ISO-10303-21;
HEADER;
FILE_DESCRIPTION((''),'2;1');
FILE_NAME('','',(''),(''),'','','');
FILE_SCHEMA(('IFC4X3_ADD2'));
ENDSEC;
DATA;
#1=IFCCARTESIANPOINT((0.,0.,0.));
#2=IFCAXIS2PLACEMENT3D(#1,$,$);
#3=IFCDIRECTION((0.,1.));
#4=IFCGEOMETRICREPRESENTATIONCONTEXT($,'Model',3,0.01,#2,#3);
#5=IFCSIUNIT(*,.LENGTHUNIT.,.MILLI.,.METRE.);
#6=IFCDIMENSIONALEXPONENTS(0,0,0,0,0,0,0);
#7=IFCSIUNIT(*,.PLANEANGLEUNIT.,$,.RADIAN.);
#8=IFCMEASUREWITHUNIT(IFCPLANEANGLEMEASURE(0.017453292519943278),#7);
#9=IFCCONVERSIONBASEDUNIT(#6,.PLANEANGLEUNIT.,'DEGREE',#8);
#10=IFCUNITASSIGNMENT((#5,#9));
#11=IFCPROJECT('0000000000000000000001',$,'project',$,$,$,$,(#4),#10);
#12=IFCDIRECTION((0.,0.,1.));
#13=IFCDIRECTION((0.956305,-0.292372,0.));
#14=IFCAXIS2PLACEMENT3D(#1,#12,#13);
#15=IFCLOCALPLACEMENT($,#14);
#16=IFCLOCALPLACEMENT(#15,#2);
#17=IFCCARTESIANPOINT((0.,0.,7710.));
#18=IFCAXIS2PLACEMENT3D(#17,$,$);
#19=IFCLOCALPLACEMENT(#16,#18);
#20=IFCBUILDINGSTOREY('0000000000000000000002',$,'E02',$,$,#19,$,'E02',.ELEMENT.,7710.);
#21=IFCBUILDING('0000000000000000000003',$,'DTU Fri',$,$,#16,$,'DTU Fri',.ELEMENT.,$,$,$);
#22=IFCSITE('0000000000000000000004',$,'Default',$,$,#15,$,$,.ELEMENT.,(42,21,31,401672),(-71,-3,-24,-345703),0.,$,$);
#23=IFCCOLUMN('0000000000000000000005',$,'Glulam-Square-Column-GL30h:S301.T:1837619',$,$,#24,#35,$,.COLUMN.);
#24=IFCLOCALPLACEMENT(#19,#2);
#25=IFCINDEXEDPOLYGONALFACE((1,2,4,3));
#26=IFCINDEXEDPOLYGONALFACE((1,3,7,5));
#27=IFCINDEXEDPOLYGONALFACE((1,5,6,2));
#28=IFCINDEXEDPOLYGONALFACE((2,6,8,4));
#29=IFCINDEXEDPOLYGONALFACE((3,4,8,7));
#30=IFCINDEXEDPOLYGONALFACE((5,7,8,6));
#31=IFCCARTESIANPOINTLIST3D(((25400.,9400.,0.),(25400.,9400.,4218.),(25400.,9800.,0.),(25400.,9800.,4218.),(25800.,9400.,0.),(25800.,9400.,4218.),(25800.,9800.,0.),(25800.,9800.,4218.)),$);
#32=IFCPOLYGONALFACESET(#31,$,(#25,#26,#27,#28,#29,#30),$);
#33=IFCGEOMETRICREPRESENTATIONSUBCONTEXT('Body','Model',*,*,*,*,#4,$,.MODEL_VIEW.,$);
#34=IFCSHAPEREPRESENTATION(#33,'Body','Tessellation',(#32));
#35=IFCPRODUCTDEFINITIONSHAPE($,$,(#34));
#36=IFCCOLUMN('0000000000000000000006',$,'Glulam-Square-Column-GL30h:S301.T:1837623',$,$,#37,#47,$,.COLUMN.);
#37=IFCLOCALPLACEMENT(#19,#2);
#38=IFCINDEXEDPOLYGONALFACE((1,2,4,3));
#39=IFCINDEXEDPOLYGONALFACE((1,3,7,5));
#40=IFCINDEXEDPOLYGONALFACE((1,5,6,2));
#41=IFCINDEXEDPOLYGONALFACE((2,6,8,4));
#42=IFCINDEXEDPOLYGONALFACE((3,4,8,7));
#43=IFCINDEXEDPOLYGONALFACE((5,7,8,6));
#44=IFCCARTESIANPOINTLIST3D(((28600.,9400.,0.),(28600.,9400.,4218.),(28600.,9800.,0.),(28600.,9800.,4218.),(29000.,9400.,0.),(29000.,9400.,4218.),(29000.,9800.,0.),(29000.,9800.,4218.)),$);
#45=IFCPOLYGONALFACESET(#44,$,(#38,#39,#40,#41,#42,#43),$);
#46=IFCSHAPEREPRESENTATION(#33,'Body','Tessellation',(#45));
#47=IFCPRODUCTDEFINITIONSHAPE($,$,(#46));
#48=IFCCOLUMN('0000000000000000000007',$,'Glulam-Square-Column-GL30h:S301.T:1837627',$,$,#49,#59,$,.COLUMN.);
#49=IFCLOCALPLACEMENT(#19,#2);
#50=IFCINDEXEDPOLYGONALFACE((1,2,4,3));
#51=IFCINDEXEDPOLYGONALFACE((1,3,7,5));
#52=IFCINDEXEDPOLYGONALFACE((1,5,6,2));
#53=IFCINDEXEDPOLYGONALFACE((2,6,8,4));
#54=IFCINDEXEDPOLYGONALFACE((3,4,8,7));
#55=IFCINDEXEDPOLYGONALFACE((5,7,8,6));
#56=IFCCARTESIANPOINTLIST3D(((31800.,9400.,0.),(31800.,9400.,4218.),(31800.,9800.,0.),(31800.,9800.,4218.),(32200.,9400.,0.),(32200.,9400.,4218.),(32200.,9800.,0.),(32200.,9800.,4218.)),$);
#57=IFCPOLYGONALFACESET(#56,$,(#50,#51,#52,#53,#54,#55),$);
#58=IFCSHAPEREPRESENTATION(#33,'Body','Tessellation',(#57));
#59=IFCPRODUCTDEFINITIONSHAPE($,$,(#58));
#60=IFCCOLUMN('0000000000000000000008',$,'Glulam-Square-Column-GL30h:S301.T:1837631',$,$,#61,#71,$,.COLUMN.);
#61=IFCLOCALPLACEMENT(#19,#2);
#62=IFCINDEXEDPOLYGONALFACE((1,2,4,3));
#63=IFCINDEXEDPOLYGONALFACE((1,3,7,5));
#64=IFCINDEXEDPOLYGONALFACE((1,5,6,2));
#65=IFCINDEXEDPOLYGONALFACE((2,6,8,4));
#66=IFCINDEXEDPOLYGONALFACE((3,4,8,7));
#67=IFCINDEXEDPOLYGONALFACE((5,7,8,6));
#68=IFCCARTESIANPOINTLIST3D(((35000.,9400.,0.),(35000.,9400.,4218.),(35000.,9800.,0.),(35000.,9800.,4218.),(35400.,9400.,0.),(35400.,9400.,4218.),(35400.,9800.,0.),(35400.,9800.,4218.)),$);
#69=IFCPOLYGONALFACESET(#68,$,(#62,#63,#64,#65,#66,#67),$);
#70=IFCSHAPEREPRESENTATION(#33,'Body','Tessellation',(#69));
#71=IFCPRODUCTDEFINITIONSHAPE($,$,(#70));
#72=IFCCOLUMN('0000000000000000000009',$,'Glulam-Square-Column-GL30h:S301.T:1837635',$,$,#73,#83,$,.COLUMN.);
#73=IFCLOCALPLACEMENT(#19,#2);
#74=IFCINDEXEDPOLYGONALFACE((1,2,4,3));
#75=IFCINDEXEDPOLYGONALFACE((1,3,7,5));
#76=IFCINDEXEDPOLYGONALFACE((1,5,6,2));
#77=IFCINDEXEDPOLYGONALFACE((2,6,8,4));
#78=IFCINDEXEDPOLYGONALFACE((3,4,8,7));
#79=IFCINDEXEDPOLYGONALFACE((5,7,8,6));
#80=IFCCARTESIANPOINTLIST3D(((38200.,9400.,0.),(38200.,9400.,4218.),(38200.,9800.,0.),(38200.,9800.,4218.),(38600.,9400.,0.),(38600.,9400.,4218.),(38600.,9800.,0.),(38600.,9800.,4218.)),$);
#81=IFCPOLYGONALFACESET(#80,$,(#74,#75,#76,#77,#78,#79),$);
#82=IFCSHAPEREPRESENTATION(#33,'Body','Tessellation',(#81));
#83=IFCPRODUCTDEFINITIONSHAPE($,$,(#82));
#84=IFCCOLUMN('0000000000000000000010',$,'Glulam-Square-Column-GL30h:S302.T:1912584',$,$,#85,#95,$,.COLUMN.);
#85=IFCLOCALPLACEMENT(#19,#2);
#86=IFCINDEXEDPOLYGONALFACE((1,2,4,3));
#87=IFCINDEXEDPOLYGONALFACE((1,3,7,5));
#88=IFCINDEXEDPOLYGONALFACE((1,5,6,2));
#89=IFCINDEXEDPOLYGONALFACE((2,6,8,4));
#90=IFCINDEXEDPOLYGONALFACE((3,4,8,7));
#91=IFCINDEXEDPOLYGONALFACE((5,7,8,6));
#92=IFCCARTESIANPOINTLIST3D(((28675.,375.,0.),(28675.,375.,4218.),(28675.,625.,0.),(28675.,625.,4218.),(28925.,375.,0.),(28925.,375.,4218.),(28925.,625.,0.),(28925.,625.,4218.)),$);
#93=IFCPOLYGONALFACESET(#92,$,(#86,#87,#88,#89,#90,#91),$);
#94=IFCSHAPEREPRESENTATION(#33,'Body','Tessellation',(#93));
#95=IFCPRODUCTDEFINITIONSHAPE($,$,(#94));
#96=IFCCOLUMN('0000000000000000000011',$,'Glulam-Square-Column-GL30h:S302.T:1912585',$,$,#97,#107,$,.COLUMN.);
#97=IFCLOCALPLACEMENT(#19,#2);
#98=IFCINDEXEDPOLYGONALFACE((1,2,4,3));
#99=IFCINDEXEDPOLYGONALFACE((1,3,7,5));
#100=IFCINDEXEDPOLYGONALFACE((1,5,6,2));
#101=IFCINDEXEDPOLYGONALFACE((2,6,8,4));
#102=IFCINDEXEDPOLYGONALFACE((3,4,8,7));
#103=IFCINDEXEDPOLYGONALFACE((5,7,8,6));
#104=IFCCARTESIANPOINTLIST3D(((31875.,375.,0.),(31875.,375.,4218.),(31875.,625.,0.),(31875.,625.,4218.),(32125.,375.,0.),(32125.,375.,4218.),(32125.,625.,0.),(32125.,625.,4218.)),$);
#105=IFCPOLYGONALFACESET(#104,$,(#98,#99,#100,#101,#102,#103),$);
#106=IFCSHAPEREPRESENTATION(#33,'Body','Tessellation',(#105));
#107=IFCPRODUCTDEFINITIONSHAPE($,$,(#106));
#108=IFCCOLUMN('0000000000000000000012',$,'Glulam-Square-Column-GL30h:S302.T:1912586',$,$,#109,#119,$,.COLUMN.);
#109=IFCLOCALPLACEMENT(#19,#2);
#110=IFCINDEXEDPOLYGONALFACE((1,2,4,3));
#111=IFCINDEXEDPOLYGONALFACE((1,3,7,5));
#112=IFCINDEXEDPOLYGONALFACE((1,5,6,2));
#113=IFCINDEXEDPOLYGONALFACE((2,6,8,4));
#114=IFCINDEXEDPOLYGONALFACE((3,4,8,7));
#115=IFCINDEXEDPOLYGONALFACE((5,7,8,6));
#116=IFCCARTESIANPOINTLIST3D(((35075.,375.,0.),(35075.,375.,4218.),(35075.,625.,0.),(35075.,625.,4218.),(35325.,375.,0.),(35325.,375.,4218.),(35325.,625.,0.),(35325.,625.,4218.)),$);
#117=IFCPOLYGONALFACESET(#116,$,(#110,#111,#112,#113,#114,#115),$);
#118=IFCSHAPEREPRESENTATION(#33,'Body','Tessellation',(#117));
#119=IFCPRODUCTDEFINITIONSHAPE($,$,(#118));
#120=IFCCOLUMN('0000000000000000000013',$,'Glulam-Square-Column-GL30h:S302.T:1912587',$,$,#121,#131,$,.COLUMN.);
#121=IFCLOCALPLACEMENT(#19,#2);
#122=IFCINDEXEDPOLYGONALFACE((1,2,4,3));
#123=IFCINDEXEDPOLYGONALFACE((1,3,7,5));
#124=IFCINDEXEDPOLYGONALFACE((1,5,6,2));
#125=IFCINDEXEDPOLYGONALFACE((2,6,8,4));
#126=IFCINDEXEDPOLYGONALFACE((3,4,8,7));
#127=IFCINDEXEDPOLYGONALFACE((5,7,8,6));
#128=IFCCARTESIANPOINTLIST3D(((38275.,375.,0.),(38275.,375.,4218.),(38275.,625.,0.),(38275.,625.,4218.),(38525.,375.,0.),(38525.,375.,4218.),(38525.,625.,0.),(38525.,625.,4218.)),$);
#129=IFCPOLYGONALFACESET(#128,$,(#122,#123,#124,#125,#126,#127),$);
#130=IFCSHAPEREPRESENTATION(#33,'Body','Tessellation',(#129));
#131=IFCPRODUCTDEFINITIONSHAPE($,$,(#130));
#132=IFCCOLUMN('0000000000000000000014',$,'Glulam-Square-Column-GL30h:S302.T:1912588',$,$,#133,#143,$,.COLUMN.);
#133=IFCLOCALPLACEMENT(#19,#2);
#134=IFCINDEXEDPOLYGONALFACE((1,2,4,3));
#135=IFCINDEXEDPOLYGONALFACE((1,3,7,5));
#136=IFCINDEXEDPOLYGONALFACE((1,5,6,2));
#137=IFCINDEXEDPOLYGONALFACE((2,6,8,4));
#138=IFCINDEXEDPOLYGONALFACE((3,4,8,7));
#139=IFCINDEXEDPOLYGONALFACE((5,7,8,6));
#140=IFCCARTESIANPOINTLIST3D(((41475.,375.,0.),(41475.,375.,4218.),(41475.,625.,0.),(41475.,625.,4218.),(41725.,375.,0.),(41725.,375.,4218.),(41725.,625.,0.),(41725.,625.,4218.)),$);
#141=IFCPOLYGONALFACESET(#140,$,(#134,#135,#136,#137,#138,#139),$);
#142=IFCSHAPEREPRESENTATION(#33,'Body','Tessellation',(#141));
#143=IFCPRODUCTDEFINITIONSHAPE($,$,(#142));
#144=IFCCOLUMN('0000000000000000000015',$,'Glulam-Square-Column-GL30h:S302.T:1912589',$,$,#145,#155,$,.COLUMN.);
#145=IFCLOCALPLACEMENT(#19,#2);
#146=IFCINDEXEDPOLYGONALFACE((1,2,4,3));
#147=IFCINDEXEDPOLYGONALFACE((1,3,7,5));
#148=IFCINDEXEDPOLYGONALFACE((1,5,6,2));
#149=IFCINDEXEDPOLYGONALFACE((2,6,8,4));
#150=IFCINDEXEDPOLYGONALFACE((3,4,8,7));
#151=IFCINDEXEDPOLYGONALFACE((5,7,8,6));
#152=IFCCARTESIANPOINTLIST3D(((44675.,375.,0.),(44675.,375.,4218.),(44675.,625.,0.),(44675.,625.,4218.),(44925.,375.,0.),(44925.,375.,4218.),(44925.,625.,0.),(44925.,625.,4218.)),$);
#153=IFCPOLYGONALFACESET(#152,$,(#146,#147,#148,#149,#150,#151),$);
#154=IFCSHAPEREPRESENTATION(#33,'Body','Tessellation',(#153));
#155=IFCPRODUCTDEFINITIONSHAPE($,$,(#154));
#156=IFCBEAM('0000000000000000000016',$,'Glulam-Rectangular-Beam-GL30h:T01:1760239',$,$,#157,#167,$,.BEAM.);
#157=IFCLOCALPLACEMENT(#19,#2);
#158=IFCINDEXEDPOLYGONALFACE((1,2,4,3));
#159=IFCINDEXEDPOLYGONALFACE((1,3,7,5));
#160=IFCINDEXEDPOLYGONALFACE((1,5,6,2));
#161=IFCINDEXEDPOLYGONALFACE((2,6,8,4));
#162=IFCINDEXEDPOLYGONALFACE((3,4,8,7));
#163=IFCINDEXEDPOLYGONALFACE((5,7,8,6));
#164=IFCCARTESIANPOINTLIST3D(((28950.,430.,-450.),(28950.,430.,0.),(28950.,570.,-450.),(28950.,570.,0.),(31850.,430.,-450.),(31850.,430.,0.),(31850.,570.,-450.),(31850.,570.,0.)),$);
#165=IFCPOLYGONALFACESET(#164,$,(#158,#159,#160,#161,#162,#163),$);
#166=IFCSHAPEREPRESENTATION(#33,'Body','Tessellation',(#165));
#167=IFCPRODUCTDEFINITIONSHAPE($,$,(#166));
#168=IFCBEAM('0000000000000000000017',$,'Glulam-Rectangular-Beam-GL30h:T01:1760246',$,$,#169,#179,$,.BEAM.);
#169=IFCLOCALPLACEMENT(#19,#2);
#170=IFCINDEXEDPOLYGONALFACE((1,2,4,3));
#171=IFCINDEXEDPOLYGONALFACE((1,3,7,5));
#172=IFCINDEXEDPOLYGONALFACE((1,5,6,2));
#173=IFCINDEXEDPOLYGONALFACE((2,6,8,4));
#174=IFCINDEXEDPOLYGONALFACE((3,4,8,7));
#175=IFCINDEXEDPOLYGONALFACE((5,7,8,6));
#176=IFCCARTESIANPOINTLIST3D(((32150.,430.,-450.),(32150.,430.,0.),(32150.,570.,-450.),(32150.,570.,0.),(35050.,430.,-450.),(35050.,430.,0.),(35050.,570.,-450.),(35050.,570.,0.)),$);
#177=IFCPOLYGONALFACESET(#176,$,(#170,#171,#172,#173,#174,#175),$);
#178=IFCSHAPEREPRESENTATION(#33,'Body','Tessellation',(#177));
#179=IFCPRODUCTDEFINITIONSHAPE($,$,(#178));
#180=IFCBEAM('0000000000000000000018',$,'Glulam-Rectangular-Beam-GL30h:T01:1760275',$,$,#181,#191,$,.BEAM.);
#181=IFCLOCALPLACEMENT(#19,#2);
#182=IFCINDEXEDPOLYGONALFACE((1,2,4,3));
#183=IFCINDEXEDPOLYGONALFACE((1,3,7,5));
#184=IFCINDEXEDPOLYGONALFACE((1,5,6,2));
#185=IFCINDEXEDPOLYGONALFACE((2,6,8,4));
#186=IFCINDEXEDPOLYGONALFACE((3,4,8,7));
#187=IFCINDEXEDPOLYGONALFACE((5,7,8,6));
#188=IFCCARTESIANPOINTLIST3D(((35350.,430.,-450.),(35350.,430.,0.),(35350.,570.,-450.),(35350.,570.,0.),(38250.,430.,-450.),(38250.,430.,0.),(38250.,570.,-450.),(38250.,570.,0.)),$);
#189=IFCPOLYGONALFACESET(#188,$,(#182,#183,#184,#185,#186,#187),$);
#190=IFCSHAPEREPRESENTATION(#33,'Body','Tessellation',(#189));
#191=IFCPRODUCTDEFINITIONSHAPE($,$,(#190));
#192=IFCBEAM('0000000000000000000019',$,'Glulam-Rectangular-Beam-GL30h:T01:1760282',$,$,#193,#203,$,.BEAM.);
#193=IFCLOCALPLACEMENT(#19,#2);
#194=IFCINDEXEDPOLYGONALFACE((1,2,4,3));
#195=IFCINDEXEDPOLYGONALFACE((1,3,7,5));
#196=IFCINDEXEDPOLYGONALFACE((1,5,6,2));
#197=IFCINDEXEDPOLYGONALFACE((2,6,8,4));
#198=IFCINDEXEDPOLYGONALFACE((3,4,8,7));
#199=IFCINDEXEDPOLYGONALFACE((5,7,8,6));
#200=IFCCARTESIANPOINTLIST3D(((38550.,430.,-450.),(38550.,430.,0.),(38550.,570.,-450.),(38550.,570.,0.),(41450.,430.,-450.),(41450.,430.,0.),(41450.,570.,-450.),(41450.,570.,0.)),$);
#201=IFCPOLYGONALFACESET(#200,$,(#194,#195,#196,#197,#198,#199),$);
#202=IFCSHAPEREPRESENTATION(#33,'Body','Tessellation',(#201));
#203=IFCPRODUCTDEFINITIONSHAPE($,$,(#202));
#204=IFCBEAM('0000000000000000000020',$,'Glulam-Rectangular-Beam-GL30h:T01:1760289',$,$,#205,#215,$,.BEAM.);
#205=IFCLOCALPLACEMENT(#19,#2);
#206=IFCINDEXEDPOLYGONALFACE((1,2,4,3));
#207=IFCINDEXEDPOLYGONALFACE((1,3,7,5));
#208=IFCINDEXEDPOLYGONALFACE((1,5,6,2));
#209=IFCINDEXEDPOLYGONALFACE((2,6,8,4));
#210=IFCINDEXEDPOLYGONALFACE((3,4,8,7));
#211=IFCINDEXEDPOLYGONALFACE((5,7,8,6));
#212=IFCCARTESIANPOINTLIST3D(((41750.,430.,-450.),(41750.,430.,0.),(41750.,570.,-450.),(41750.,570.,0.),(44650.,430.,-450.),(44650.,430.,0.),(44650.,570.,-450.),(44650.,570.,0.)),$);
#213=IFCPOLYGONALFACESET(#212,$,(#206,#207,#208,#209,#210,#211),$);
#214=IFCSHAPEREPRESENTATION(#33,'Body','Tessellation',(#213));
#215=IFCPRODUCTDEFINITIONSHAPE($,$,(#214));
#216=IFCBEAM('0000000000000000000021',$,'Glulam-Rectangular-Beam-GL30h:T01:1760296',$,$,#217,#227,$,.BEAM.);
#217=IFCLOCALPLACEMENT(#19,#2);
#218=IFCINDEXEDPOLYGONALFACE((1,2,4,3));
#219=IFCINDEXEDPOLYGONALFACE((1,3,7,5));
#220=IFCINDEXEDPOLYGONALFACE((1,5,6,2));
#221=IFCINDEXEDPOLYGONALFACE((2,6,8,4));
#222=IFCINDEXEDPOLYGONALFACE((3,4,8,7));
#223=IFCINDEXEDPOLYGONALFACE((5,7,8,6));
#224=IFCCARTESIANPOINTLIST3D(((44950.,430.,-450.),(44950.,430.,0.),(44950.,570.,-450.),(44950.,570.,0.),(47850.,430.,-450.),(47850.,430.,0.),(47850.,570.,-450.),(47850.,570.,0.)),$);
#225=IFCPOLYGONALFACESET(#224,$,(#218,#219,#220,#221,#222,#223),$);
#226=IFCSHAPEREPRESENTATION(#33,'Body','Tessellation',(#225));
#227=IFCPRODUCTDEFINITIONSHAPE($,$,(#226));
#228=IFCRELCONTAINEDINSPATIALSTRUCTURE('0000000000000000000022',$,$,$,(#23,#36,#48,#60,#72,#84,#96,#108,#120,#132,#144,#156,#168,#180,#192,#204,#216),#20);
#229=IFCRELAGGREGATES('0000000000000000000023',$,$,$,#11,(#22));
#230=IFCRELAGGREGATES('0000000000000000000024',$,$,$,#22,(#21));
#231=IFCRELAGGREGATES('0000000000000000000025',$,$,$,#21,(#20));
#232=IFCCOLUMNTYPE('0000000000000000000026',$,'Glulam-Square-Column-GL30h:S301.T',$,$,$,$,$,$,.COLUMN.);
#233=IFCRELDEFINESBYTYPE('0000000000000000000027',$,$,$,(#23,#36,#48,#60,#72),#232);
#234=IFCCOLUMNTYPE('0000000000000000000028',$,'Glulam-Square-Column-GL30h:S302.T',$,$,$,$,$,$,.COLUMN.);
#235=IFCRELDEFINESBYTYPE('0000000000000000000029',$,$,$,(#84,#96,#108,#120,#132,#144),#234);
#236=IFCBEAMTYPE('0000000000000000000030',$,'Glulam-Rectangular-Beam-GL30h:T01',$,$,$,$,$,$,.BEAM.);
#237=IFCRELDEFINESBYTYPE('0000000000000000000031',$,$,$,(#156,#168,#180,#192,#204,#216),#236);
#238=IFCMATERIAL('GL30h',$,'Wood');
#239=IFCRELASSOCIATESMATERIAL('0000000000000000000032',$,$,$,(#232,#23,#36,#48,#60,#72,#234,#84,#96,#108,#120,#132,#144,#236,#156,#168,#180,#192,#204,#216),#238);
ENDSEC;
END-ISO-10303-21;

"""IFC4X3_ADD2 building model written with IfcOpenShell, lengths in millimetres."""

from ifc_helpers import new_model, entity, si_unit, converted_unit, direction, frame, origin, origin_2d_with_axis, place, context, subcontext, project, spatial, rectangle, extrude, source, transform, mapped, material, material_profile, profile_set, profile_usage, type_object, type_shapes, element, save


model = new_model("IFC4X3_ADD2")

# Units and contexts
model_context = context("Model", 3, precision=0.01, world=origin(), true_north=direction((0.0, 1.0)))
body_context = subcontext(model_context, "Body", "Model", "MODEL_VIEW")
ifc_project = project(units=[si_unit("LENGTHUNIT", "METRE", prefix="MILLI"), converted_unit("PLANEANGLEUNIT", "DEGREE", entity("IfcPlaneAngleMeasure", 0.017453292519943278), si_unit("PLANEANGLEUNIT", "RADIAN"), dimensions=[0, 0, 0, 0, 0, 0, 0])], contexts=[model_context])

# Site, building, storey
site_placement = place(None, frame((0.0, 0.0, 0.0), z_axis=(0.0, 0.0, 1.0), x_axis=(0.956305, -0.292372, 0.0)))
site = spatial("IfcSite", under=ifc_project, at=site_placement, Name="Default", CompositionType="ELEMENT", RefLatitude=(42, 21, 31, 401672), RefLongitude=(-71, -3, -24, -345703), RefElevation=0.0)
building_placement = place(site_placement, origin())
building = spatial("IfcBuilding", under=site, at=building_placement, Name="DTU Fri", LongName="DTU Fri", CompositionType="ELEMENT")
storey_placement = place(building_placement, frame((0.0, 0.0, 7710.0)))
storey = spatial("IfcBuildingStorey", under=building, at=storey_placement, Name="E02", LongName="E02", CompositionType="ELEMENT", Elevation=7710.0)

# Columns
ifc_material = material(Name="GL30h", Category="Wood")
ifc_material_profile_1 = material_profile(ifc_material, rectangle(XDim=400.0, YDim=400.0, at=origin_2d_with_axis()), Name="S301.T")
ifc_profile_set_1 = profile_set([ifc_material_profile_1], Name="S301.T")
ifc_profile_usage_1 = profile_usage(ifc_profile_set_1)
column_type_1 = type_object("IfcColumnType", Name="Glulam-Square-Column-GL30h:S301.T", PredefinedType="COLUMN", material=ifc_profile_set_1)
shared_shape_1 = source(origin(), body_context, "Body", "SweptSolid", [
    extrude(rectangle(XDim=400.0, YDim=400.0, at=origin_2d_with_axis()), frame((0.0, 0.0, 7710.0), z_axis=(0.0, 0.0, 1.0), x_axis=(0.0, 1.0, 0.0)), (0.0, 0.0, 1.0), 4218.0),
])
type_shapes(column_type_1, [shared_shape_1])
for number, where, name in (
    (1, (25600.0, 9600.0, -7710.0), "Glulam-Square-Column-GL30h:S301.T:1837619"),
    (2, (28800.0, 9600.0, -7710.0), "Glulam-Square-Column-GL30h:S301.T:1837623"),
    (3, (32000.0, 9600.0, -7710.0), "Glulam-Square-Column-GL30h:S301.T:1837627"),
    (4, (35200.0, 9600.0, -7710.0), "Glulam-Square-Column-GL30h:S301.T:1837631"),
    (5, (38400.0, 9600.0, -7710.0), "Glulam-Square-Column-GL30h:S301.T:1837635"),
):
    element("IfcColumn", number, at=place(storey_placement, frame(where)), inside=storey, type_object=column_type_1, material=ifc_profile_usage_1, Name=name, PredefinedType="COLUMN", context=body_context, shape_type="MappedRepresentation", body=[
        mapped(shared_shape_1, transform((0.0, 0.0, 0.0), scale=1.0)),
    ])
ifc_material_profile_2 = material_profile(ifc_material, rectangle(XDim=250.0, YDim=250.0, at=origin_2d_with_axis()), Name="S302.T")
ifc_profile_set_2 = profile_set([ifc_material_profile_2], Name="S302.T")
ifc_profile_usage_2 = profile_usage(ifc_profile_set_2)
column_type_2 = type_object("IfcColumnType", Name="Glulam-Square-Column-GL30h:S302.T", PredefinedType="COLUMN", material=ifc_profile_set_2)
shared_shape_2 = source(origin(), body_context, "Body", "SweptSolid", [
    extrude(rectangle(XDim=250.0, YDim=250.0, at=origin_2d_with_axis()), frame((0.0, 0.0, 7710.0), z_axis=(0.0, 0.0, 1.0), x_axis=(0.0, 1.0, 0.0)), (0.0, 0.0, 1.0), 4218.0),
])
type_shapes(column_type_2, [shared_shape_2])
for number, where, name in (
    (6, (28800.0, 500.0, -7710.0), "Glulam-Square-Column-GL30h:S302.T:1912584"),
    (7, (32000.0, 500.0, -7710.0), "Glulam-Square-Column-GL30h:S302.T:1912585"),
    (8, (35200.0, 500.0, -7710.0), "Glulam-Square-Column-GL30h:S302.T:1912586"),
    (9, (38400.0, 500.0, -7710.0), "Glulam-Square-Column-GL30h:S302.T:1912587"),
    (10, (41600.0, 500.0, -7710.0), "Glulam-Square-Column-GL30h:S302.T:1912588"),
    (11, (44800.0, 500.0, -7710.0), "Glulam-Square-Column-GL30h:S302.T:1912589"),
):
    element("IfcColumn", number, at=place(storey_placement, frame(where)), inside=storey, type_object=column_type_2, material=ifc_profile_usage_2, Name=name, PredefinedType="COLUMN", context=body_context, shape_type="MappedRepresentation", body=[
        mapped(shared_shape_2, transform((0.0, 0.0, 0.0), scale=1.0)),
    ])

# Beams
ifc_material_profile_3 = material_profile(ifc_material, rectangle(XDim=450.0, YDim=140.0, at=origin_2d_with_axis()), Name="T01")
ifc_profile_set_3 = profile_set([ifc_material_profile_3], Name="T01")
ifc_profile_usage_3 = profile_usage(ifc_profile_set_3, cardinal=8)
beam_type_1 = type_object("IfcBeamType", Name="Glulam-Rectangular-Beam-GL30h:T01", PredefinedType="BEAM", material=ifc_profile_set_3)
shared_shape_3 = source(origin(), body_context, "Body", "SweptSolid", [
    extrude(rectangle(XDim=450.0, YDim=140.0, at=origin_2d_with_axis()), frame((-1450.0, 0.0, 0.0), z_axis=(1.0, 0.0, 0.0), x_axis=(0.0, 0.0, -1.0)), (0.0, 0.0, 1.0), 2900.0),
])
type_shapes(beam_type_1, [shared_shape_3])
for number, where, name in (
    (12, (30400.0, 500.0, -225.0), "Glulam-Rectangular-Beam-GL30h:T01:1760239"),
    (13, (33600.0, 500.0, -225.0), "Glulam-Rectangular-Beam-GL30h:T01:1760246"),
    (14, (36800.0, 500.0, -225.0), "Glulam-Rectangular-Beam-GL30h:T01:1760275"),
    (15, (40000.0, 500.0, -225.0), "Glulam-Rectangular-Beam-GL30h:T01:1760282"),
    (16, (43200.0, 500.0, -225.0), "Glulam-Rectangular-Beam-GL30h:T01:1760289"),
    (17, (46400.0, 500.0, -225.0), "Glulam-Rectangular-Beam-GL30h:T01:1760296"),
):
    element("IfcBeam", number, at=place(storey_placement, frame(where)), inside=storey, type_object=beam_type_1, material=ifc_profile_usage_3, Name=name, PredefinedType="BEAM", context=body_context, shape_type="MappedRepresentation", body=[
        mapped(shared_shape_3, transform((0.0, 0.0, 0.0), scale=1.0)),
    ])

save(model, "model.ifc")
